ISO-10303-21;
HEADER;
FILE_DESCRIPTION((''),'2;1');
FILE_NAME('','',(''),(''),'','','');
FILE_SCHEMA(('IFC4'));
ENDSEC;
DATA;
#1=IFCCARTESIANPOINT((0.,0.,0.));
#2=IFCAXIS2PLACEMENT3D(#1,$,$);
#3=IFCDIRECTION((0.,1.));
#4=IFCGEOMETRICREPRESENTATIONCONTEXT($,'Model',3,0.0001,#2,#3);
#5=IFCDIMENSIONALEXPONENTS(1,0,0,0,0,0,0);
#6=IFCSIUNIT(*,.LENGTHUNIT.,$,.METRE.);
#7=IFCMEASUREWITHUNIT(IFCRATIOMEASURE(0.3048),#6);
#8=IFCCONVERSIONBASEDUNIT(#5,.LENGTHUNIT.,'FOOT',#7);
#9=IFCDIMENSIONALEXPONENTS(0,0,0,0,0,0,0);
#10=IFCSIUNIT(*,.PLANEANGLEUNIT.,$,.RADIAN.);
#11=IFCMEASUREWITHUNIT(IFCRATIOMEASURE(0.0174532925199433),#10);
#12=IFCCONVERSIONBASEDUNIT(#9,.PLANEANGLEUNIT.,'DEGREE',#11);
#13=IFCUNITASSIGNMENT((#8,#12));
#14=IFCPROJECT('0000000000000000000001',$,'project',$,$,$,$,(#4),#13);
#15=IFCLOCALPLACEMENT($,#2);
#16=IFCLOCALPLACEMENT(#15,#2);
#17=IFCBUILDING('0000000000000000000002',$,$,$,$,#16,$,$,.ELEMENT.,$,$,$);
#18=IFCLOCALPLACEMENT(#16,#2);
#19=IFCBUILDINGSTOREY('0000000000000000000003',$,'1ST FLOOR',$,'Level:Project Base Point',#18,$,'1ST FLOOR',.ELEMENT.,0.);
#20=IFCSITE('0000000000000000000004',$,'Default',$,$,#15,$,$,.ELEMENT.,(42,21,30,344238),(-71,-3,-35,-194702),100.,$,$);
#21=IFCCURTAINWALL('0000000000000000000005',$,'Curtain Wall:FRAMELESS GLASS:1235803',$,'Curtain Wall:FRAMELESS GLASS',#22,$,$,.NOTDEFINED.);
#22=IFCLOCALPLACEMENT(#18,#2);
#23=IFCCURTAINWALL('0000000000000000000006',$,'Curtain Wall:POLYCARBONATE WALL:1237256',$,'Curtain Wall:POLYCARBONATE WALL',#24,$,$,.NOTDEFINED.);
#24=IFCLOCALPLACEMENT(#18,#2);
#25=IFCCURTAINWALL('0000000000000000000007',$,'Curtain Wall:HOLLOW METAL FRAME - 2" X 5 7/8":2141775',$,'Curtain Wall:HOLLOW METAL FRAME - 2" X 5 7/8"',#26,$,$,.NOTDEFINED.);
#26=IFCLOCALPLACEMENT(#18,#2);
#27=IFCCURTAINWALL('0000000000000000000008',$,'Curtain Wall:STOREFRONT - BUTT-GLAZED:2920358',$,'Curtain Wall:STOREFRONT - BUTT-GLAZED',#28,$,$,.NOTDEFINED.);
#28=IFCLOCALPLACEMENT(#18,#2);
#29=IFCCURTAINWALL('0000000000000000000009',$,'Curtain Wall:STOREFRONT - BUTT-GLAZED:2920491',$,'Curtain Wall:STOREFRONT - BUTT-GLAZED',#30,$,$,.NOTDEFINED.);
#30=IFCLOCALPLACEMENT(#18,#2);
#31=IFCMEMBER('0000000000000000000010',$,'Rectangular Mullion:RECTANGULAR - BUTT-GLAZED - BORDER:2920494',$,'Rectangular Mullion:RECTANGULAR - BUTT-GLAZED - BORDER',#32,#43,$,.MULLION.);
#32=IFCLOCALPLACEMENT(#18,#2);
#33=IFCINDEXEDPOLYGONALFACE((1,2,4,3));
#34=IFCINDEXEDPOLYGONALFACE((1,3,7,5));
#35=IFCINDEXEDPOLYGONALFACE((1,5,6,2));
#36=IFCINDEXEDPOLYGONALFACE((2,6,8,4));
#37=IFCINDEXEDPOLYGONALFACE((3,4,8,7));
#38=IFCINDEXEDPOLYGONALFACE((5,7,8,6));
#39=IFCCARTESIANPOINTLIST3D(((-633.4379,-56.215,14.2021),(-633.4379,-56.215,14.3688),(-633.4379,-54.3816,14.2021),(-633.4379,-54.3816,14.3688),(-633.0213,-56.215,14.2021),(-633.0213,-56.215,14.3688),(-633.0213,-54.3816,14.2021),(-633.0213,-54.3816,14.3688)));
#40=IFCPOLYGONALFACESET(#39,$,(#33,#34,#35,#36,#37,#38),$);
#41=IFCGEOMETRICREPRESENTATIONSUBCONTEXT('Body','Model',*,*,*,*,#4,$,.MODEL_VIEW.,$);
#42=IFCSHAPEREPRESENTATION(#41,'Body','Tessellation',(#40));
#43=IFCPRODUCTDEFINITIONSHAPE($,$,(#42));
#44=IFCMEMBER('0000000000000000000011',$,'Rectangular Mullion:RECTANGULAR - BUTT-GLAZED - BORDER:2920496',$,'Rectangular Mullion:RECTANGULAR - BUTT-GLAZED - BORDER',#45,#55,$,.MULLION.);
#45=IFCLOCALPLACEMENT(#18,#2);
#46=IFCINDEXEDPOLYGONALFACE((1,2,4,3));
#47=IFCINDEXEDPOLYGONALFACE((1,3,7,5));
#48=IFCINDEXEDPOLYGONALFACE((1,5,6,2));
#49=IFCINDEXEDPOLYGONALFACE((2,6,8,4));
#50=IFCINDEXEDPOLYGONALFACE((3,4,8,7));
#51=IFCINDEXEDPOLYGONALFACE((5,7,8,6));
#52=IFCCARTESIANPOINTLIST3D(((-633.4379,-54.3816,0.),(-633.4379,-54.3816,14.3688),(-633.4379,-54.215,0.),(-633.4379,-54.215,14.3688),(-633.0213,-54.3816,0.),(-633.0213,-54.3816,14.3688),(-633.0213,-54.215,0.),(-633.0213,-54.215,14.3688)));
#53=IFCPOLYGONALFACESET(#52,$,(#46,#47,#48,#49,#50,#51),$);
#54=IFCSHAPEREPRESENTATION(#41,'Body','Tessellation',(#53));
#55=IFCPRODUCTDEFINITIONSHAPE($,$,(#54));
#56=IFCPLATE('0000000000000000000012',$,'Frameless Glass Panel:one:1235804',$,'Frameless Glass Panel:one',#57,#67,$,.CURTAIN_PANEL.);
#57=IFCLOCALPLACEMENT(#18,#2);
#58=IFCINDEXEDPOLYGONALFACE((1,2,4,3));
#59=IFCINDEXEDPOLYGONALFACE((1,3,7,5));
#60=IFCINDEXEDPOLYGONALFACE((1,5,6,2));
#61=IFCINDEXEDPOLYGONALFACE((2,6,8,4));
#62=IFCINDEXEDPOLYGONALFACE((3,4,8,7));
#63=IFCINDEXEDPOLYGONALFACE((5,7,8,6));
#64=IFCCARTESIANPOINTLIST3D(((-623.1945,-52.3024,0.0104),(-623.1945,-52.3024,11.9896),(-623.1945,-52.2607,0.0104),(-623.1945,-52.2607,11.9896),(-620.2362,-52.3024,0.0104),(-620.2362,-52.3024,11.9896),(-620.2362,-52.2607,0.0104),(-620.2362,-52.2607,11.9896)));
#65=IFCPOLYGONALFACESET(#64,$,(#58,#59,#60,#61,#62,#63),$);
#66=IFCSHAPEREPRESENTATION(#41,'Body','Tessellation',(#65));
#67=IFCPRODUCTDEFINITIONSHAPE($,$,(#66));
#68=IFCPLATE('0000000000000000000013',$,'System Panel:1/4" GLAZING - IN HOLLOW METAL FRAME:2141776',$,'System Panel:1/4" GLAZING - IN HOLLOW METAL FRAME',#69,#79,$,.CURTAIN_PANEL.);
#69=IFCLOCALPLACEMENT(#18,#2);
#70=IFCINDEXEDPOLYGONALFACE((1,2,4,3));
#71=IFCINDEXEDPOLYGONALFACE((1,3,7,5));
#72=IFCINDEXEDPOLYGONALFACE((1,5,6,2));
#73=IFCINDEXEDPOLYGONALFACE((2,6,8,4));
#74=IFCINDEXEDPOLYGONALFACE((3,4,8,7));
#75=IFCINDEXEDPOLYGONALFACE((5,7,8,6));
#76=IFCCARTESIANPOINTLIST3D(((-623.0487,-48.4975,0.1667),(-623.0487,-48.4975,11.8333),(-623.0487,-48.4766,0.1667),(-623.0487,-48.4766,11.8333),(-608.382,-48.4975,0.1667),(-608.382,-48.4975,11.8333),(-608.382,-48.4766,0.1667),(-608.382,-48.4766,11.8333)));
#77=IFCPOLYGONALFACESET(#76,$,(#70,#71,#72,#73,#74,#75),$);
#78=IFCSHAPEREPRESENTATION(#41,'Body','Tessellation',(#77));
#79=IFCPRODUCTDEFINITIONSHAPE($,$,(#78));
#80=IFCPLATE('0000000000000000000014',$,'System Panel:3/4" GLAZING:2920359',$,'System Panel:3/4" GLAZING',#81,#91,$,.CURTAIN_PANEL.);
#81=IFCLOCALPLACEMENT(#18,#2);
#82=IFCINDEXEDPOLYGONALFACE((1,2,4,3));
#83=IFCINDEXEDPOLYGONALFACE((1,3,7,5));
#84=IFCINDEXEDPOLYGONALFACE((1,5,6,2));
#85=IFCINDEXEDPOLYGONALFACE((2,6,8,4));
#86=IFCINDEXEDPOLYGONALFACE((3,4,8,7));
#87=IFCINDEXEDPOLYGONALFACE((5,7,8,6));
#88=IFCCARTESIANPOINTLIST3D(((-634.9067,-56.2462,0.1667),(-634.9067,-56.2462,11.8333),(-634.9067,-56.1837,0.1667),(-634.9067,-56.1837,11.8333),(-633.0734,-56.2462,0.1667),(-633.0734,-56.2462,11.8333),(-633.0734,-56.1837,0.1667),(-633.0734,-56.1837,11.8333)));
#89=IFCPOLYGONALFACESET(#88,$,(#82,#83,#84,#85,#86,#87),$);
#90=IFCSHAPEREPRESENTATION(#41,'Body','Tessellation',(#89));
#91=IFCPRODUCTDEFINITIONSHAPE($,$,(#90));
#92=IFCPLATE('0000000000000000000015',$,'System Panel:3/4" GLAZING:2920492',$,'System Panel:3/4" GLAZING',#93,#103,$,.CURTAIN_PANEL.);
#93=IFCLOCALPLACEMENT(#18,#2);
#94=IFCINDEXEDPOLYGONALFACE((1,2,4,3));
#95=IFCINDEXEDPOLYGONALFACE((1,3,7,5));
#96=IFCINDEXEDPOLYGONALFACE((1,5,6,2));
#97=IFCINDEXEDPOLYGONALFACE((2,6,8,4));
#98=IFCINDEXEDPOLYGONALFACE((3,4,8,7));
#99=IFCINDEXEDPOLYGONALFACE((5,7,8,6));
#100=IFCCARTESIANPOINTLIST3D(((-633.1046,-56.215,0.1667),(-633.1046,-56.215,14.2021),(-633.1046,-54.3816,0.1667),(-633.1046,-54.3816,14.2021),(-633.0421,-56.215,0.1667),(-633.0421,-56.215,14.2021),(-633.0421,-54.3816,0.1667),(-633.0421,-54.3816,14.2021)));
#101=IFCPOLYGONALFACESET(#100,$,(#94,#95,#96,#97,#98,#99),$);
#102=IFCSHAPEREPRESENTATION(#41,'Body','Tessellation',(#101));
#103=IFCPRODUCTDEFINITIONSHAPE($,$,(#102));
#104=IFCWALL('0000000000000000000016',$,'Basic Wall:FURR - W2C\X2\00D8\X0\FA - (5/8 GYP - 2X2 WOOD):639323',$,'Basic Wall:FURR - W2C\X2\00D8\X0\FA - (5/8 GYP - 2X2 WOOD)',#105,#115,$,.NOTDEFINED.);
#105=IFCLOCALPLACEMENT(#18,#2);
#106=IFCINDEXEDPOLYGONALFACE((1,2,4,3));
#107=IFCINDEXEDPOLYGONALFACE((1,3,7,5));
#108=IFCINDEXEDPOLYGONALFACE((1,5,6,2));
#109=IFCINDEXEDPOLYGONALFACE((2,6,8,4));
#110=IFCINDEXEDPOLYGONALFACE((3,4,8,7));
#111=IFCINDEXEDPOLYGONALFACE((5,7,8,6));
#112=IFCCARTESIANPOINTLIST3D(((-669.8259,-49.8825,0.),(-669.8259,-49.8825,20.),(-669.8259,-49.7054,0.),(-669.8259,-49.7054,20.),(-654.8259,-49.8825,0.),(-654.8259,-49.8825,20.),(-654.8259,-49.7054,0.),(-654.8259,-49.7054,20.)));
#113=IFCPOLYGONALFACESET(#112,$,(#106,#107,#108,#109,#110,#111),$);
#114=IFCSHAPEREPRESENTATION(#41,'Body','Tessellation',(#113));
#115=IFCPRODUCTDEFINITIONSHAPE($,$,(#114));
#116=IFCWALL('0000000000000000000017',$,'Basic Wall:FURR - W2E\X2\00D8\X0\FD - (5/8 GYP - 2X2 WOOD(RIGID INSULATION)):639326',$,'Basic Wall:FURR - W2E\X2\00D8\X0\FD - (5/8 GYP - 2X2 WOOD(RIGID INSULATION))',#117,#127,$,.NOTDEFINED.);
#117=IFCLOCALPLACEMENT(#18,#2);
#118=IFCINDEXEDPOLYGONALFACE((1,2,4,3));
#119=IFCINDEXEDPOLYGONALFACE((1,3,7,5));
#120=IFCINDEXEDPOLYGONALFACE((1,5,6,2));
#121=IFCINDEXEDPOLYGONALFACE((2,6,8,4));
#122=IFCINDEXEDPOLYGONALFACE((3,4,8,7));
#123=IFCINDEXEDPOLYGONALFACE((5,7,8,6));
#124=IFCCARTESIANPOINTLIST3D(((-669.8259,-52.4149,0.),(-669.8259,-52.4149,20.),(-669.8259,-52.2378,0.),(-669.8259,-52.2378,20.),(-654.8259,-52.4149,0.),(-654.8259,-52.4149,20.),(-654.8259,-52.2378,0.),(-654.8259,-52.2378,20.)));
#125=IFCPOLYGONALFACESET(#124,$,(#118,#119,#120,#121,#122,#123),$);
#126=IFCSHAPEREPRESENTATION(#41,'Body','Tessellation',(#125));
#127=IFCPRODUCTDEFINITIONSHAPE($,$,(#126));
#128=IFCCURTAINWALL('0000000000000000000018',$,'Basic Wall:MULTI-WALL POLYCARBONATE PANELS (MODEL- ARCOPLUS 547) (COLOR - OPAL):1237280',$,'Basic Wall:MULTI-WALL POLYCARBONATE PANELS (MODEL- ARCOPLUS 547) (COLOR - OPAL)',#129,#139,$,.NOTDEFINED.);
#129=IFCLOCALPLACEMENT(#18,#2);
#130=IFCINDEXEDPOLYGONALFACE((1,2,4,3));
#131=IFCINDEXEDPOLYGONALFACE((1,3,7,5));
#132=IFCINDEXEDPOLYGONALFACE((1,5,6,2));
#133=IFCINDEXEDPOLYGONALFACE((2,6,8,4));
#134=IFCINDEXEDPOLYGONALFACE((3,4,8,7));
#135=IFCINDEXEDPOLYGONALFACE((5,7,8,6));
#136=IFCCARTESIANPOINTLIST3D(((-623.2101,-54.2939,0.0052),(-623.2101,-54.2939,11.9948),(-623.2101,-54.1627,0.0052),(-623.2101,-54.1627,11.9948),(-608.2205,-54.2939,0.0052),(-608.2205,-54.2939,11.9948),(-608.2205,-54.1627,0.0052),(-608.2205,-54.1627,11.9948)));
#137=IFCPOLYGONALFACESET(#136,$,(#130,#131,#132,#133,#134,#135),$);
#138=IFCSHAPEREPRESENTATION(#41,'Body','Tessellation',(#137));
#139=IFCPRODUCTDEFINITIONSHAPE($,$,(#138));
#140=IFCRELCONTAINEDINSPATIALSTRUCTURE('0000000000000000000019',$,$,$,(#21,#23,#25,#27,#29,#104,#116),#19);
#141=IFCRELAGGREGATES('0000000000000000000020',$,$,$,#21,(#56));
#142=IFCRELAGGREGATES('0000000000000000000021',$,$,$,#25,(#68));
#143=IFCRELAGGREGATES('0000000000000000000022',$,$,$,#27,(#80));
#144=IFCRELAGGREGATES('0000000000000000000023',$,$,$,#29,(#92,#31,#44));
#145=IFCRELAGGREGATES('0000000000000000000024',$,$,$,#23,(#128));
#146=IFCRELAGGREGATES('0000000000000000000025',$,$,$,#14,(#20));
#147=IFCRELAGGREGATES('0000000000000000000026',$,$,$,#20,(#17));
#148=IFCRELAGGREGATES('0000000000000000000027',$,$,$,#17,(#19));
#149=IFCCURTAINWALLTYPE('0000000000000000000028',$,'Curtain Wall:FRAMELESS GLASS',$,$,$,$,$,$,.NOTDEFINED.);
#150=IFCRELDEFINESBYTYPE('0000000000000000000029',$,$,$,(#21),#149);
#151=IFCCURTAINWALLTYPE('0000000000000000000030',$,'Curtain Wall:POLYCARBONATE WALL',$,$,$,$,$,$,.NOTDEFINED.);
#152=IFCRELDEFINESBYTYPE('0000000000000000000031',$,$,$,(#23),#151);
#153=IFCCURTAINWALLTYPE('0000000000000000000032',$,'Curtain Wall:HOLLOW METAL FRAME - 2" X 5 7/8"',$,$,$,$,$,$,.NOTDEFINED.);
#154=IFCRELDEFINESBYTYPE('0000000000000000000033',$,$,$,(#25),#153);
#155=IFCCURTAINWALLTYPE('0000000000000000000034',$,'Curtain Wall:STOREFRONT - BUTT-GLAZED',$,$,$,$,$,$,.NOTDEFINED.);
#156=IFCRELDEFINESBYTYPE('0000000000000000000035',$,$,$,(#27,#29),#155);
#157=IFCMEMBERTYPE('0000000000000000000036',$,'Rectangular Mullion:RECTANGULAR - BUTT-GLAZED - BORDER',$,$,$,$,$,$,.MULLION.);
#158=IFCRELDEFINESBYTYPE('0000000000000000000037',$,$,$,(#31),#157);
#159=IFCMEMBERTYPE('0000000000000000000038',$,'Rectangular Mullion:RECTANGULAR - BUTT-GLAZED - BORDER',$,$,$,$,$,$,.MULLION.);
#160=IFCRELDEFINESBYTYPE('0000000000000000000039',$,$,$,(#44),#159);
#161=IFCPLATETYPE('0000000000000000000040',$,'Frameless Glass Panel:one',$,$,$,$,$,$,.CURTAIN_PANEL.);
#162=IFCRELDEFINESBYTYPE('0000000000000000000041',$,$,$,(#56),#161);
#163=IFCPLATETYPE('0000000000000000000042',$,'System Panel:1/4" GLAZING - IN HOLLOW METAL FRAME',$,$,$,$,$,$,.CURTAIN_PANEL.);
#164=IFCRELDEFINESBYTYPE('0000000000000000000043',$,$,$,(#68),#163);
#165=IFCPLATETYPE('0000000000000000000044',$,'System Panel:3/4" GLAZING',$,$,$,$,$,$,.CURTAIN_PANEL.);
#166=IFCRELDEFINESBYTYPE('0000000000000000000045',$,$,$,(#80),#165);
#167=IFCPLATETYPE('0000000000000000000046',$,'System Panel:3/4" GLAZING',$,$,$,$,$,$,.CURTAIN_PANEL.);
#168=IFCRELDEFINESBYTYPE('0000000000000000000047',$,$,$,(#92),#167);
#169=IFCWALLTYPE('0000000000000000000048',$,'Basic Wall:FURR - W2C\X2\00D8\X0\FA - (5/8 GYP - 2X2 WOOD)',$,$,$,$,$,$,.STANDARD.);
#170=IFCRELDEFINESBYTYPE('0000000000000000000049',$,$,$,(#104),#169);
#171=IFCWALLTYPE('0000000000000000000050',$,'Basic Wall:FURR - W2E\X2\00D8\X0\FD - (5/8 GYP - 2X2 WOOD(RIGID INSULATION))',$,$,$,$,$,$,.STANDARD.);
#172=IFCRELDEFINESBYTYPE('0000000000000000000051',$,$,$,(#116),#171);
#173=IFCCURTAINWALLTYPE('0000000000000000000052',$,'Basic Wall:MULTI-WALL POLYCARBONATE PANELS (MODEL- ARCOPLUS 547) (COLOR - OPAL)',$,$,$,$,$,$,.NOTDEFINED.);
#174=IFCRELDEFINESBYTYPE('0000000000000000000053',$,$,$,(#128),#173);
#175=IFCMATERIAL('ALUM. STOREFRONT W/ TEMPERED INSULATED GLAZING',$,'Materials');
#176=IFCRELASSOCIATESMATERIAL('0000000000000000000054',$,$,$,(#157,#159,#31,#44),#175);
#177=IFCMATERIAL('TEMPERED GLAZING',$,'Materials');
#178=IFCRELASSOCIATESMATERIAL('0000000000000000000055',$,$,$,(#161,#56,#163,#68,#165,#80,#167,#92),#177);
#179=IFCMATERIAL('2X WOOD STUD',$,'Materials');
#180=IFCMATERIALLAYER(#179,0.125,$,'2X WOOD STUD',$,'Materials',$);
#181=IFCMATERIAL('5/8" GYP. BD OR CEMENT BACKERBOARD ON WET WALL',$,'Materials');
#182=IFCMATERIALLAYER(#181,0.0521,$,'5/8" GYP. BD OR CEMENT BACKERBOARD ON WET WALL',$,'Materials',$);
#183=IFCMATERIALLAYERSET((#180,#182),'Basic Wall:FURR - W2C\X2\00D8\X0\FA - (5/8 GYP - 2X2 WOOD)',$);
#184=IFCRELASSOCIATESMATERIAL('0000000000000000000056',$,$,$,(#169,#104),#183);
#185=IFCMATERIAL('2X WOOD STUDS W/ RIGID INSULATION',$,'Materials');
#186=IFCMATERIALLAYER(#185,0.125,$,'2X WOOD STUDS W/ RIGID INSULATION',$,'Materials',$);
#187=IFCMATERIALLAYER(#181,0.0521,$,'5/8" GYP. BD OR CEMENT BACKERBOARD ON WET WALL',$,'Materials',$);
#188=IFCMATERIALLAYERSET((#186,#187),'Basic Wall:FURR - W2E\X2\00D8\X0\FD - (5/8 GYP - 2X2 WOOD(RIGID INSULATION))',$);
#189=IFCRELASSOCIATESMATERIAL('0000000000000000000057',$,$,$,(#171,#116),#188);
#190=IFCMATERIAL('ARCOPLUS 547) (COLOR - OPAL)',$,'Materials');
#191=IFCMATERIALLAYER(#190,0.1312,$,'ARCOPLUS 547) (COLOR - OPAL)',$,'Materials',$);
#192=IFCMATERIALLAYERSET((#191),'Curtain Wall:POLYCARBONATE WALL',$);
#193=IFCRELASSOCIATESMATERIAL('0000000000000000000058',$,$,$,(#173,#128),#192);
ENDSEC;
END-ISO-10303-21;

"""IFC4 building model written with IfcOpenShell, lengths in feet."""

from ifc_helpers import new_model, entity, si_unit, converted_unit, direction, frame, frame_2d, origin, origin_2d_with_axis, place, context, subcontext, project, spatial, rectangle, extrude, source, transform, mapped, material, layer, layer_set, layer_usage, material_profile, profile_set, profile_usage, type_object, type_shapes, element, aggregate, save


model = new_model("IFC4")

# Units and contexts
model_context = context("Model", 3, precision=0.0001, world=origin(), true_north=direction((0.0, 1.0)))
body_context = subcontext(model_context, "Body", "Model", "MODEL_VIEW")
ifc_project = project(units=[converted_unit("LENGTHUNIT", "FOOT", entity("IfcRatioMeasure", 0.3048), si_unit("LENGTHUNIT", "METRE"), dimensions=[1, 0, 0, 0, 0, 0, 0]), converted_unit("PLANEANGLEUNIT", "DEGREE", entity("IfcRatioMeasure", 0.0174532925199433), si_unit("PLANEANGLEUNIT", "RADIAN"), dimensions=[0, 0, 0, 0, 0, 0, 0])], contexts=[model_context])

# Site, building, storey
site_placement = place(None, origin())
site = spatial("IfcSite", under=ifc_project, at=site_placement, Name="Default", CompositionType="ELEMENT", RefLatitude=(42, 21, 30, 344238), RefLongitude=(-71, -3, -35, -194702), RefElevation=100.0)
building_placement = place(site_placement, origin())
building = spatial("IfcBuilding", under=site, at=building_placement, CompositionType="ELEMENT")
storey_placement = place(building_placement, origin())
storey = spatial("IfcBuildingStorey", under=building, at=storey_placement, Name="1ST FLOOR", ObjectType="Level:Project Base Point", LongName="1ST FLOOR", CompositionType="ELEMENT", Elevation=0.0)

# Curtain wall
curtain_wall_type_1 = type_object("IfcCurtainWallType", Name="Curtain Wall:FRAMELESS GLASS", PredefinedType="NOTDEFINED")
curtain_wall_1_placement = place(storey_placement, origin())
curtain_wall_1 = element("IfcCurtainWall", 1, at=curtain_wall_1_placement, inside=storey, type_object=curtain_wall_type_1, Name="Curtain Wall:FRAMELESS GLASS:1235803", ObjectType="Curtain Wall:FRAMELESS GLASS", PredefinedType="NOTDEFINED")

# Curtain wall
ifc_material_1 = material(Name="ALUM. STOREFRONT W/ TEMPERED INSULATED GLAZING", Category="Materials")
curtain_wall_type_2 = type_object("IfcCurtainWallType", Name="Curtain Wall:POLYCARBONATE WALL", PredefinedType="NOTDEFINED")
curtain_wall_2_placement = place(storey_placement, origin())
curtain_wall_2 = element("IfcCurtainWall", 2, at=curtain_wall_2_placement, inside=storey, type_object=curtain_wall_type_2, Name="Curtain Wall:POLYCARBONATE WALL:1237256", ObjectType="Curtain Wall:POLYCARBONATE WALL", PredefinedType="NOTDEFINED")

# Curtain wall
curtain_wall_type_3 = type_object("IfcCurtainWallType", Name="Curtain Wall:HOLLOW METAL FRAME - 2\" X 5 7/8\"", PredefinedType="NOTDEFINED")
curtain_wall_3_placement = place(storey_placement, origin())
curtain_wall_3 = element("IfcCurtainWall", 3, at=curtain_wall_3_placement, inside=storey, type_object=curtain_wall_type_3, Name="Curtain Wall:HOLLOW METAL FRAME - 2\" X 5 7/8\":2141775", ObjectType="Curtain Wall:HOLLOW METAL FRAME - 2\" X 5 7/8\"", PredefinedType="NOTDEFINED")

# Curtain walls, members
curtain_wall_type_4 = type_object("IfcCurtainWallType", Name="Curtain Wall:STOREFRONT - BUTT-GLAZED", PredefinedType="NOTDEFINED")
curtain_wall_4_placement = place(storey_placement, origin())
curtain_wall_4 = element("IfcCurtainWall", 4, at=curtain_wall_4_placement, inside=storey, type_object=curtain_wall_type_4, Name="Curtain Wall:STOREFRONT - BUTT-GLAZED:2920358", ObjectType="Curtain Wall:STOREFRONT - BUTT-GLAZED", PredefinedType="NOTDEFINED")
ifc_material_profile_1 = material_profile(ifc_material_1, rectangle(XDim=0.4167, YDim=0.1667, at=frame_2d((0.0, 0.0), x_axis=(1.0, 0.0))), Name="RECTANGULAR - BUTT-GLAZED - BORDER")
ifc_profile_set_1 = profile_set([ifc_material_profile_1], Name="RECTANGULAR - BUTT-GLAZED - BORDER")
curtain_wall_5_placement = place(storey_placement, origin())
curtain_wall_5 = element("IfcCurtainWall", 5, at=curtain_wall_5_placement, inside=storey, type_object=curtain_wall_type_4, Name="Curtain Wall:STOREFRONT - BUTT-GLAZED:2920491", ObjectType="Curtain Wall:STOREFRONT - BUTT-GLAZED", PredefinedType="NOTDEFINED")
ifc_profile_usage_1 = profile_usage(ifc_profile_set_1)
member_type_1 = type_object("IfcMemberType", Name="Rectangular Mullion:RECTANGULAR - BUTT-GLAZED - BORDER", PredefinedType="MULLION", material=ifc_profile_set_1)
shared_shape_1 = source(origin(), body_context, "Body", "SweptSolid", [
    extrude(rectangle(XDim=0.4167, YDim=0.1667, at=frame_2d((0.0, 0.0), x_axis=(1.0, 0.0))), frame((-0.0833, -0.1562, -1.8333), z_axis=(0.0, 0.0, 1.0), x_axis=(0.0, -1.0, 0.0)), (0.0, 0.0, 1.0), 1.8333),
])
type_shapes(member_type_1, [shared_shape_1])
member_1_placement = place(storey_placement, frame((-633.0734, -54.3816, 14.3688), z_axis=(0.0, 1.0, 0.0), x_axis=(0.0, 0.0, 1.0)))
member_1 = element("IfcMember", 6, at=member_1_placement, type_object=member_type_1, material=ifc_profile_usage_1, Name="Rectangular Mullion:RECTANGULAR - BUTT-GLAZED - BORDER:2920494", ObjectType="Rectangular Mullion:RECTANGULAR - BUTT-GLAZED - BORDER", PredefinedType="MULLION", context=body_context, shape_type="MappedRepresentation", body=[
    mapped(shared_shape_1, transform((0.0, 0.0, 0.0), scale=1.0)),
])
ifc_profile_usage_2 = profile_usage(ifc_profile_set_1)
member_type_2 = type_object("IfcMemberType", Name="Rectangular Mullion:RECTANGULAR - BUTT-GLAZED - BORDER", PredefinedType="MULLION", material=ifc_profile_set_1)
shared_shape_2 = source(origin(), body_context, "Body", "SweptSolid", [
    extrude(rectangle(XDim=0.4167, YDim=0.1667, at=frame_2d((0.0, 0.0), x_axis=(1.0, 0.0))), frame((-0.0833, -0.1562, -14.3688), z_axis=(0.0, 0.0, 1.0), x_axis=(0.0, -1.0, 0.0)), (0.0, 0.0, 1.0), 14.3688),
])
type_shapes(member_type_2, [shared_shape_2])
member_2_placement = place(storey_placement, frame((-633.0734, -54.215, 0.0), z_axis=(0.0, 0.0, -1.0), x_axis=(0.0, 1.0, 0.0)))
member_2 = element("IfcMember", 7, at=member_2_placement, type_object=member_type_2, material=ifc_profile_usage_2, Name="Rectangular Mullion:RECTANGULAR - BUTT-GLAZED - BORDER:2920496", ObjectType="Rectangular Mullion:RECTANGULAR - BUTT-GLAZED - BORDER", PredefinedType="MULLION", context=body_context, shape_type="MappedRepresentation", body=[
    mapped(shared_shape_2, transform((0.0, 0.0, 0.0), scale=1.0)),
])

# Plates
ifc_material_2 = material(Name="TEMPERED GLAZING", Category="Materials")
plate_type_1 = type_object("IfcPlateType", Name="Frameless Glass Panel:one", PredefinedType="CURTAIN_PANEL", material=ifc_material_2)
shared_shape_3 = source(origin(), body_context, "Body", "SweptSolid", [
    extrude(rectangle(XDim=0.0417, YDim=2.9583, at=origin_2d_with_axis()), frame((0.0, 0.0, 0.0), z_axis=(0.0, 0.0, 1.0), x_axis=(0.0, 1.0, 0.0)), (0.0, 0.0, 1.0), 11.9792),
])
type_shapes(plate_type_1, [shared_shape_3])
plate_1_placement = place(curtain_wall_1_placement, frame((-621.7153, -52.2815, 0.0104)))
plate_1 = element("IfcPlate", 8, at=plate_1_placement, type_object=plate_type_1, material=ifc_material_2, Name="Frameless Glass Panel:one:1235804", ObjectType="Frameless Glass Panel:one", PredefinedType="CURTAIN_PANEL", context=body_context, shape_type="MappedRepresentation", body=[
    mapped(shared_shape_3, transform((0.0, 0.0, 0.0), scale=1.0)),
])
aggregate(curtain_wall_1, [plate_1])
plate_type_2 = type_object("IfcPlateType", Name="System Panel:1/4\" GLAZING - IN HOLLOW METAL FRAME", PredefinedType="CURTAIN_PANEL", material=ifc_material_2)
shared_shape_4 = source(origin(), body_context, "Body", "SweptSolid", [
    extrude(rectangle(XDim=0.0208, YDim=14.6667, at=frame_2d((0.0, 0.0), x_axis=(1.0, 0.0))), frame((7.3333, 0.0104, 0.0), z_axis=(0.0, 0.0, 1.0), x_axis=(0.0, 1.0, 0.0)), (0.0, 0.0, 1.0), 11.6667),
])
type_shapes(plate_type_2, [shared_shape_4])
plate_2_placement = place(curtain_wall_3_placement, frame((-623.0487, -48.4975, 0.1667)))
plate_2 = element("IfcPlate", 9, at=plate_2_placement, type_object=plate_type_2, material=ifc_material_2, Name="System Panel:1/4\" GLAZING - IN HOLLOW METAL FRAME:2141776", ObjectType="System Panel:1/4\" GLAZING - IN HOLLOW METAL FRAME", PredefinedType="CURTAIN_PANEL", context=body_context, shape_type="MappedRepresentation", body=[
    mapped(shared_shape_4, transform((0.0, 0.0, 0.0), scale=1.0)),
])
aggregate(curtain_wall_3, [plate_2])
plate_type_3 = type_object("IfcPlateType", Name="System Panel:3/4\" GLAZING", PredefinedType="CURTAIN_PANEL", material=ifc_material_2)
shared_shape_5 = source(origin(), body_context, "Body", "SweptSolid", [
    extrude(rectangle(XDim=0.0625, YDim=1.8333, at=origin_2d_with_axis()), frame((0.0, 0.0, 0.0), z_axis=(0.0, 0.0, 1.0), x_axis=(0.0, 1.0, 0.0)), (0.0, 0.0, 1.0), 11.6667),
])
type_shapes(plate_type_3, [shared_shape_5])
plate_3_placement = place(curtain_wall_4_placement, frame((-633.99, -56.215, 0.1667)))
plate_3 = element("IfcPlate", 10, at=plate_3_placement, type_object=plate_type_3, material=ifc_material_2, Name="System Panel:3/4\" GLAZING:2920359", ObjectType="System Panel:3/4\" GLAZING", PredefinedType="CURTAIN_PANEL", context=body_context, shape_type="MappedRepresentation", body=[
    mapped(shared_shape_5, transform((0.0, 0.0, 0.0), scale=1.0)),
])
aggregate(curtain_wall_4, [plate_3])
plate_type_4 = type_object("IfcPlateType", Name="System Panel:3/4\" GLAZING", PredefinedType="CURTAIN_PANEL", material=ifc_material_2)
shared_shape_6 = source(origin(), body_context, "Body", "SweptSolid", [
    extrude(rectangle(XDim=0.0625, YDim=1.8333, at=origin_2d_with_axis()), frame((0.0, 0.0, 0.0), z_axis=(0.0, 0.0, 1.0), x_axis=(0.0, 1.0, 0.0)), (0.0, 0.0, 1.0), 14.0355),
])
type_shapes(plate_type_4, [shared_shape_6])
plate_4_placement = place(curtain_wall_5_placement, frame((-633.0734, -55.2983, 0.1667), z_axis=(0.0, 0.0, 1.0), x_axis=(0.0, 1.0, 0.0)))
plate_4 = element("IfcPlate", 11, at=plate_4_placement, type_object=plate_type_4, material=ifc_material_2, Name="System Panel:3/4\" GLAZING:2920492", ObjectType="System Panel:3/4\" GLAZING", PredefinedType="CURTAIN_PANEL", context=body_context, shape_type="MappedRepresentation", body=[
    mapped(shared_shape_6, transform((0.0, 0.0, 0.0), scale=1.0)),
])
aggregate(curtain_wall_5, [plate_4, member_1, member_2])

# Walls
ifc_material_3 = material(Name="2X WOOD STUD", Category="Materials")
ifc_layer_1 = layer(ifc_material_3, 0.125, Name="2X WOOD STUD", Category="Materials")
ifc_material_4 = material(Name="5/8\" GYP. BD OR CEMENT BACKERBOARD ON WET WALL", Category="Materials")
ifc_layer_2 = layer(ifc_material_4, 0.0521, Name="5/8\" GYP. BD OR CEMENT BACKERBOARD ON WET WALL", Category="Materials")
ifc_layer_set_1 = layer_set([ifc_layer_1, ifc_layer_2], Name="Basic Wall:FURR - W2CØFA - (5/8 GYP - 2X2 WOOD)")
ifc_layer_usage_1 = layer_usage(ifc_layer_set_1, "AXIS2", "NEGATIVE", 0.0885)
wall_type_1 = type_object("IfcWallType", Name="Basic Wall:FURR - W2CØFA - (5/8 GYP - 2X2 WOOD)", PredefinedType="STANDARD", material=ifc_layer_set_1)
wall_1_placement = place(storey_placement, frame((-669.8259, -49.7939, 0.0)))
element("IfcWall", 12, at=wall_1_placement, inside=storey, type_object=wall_type_1, material=ifc_layer_usage_1, Name="Basic Wall:FURR - W2CØFA - (5/8 GYP - 2X2 WOOD):639323", ObjectType="Basic Wall:FURR - W2CØFA - (5/8 GYP - 2X2 WOOD)", PredefinedType="NOTDEFINED", context=body_context, shape_type="SweptSolid", body=[
    extrude(rectangle(XDim=15.0, YDim=0.1771, at=frame_2d((7.5, 0.0), x_axis=(-1.0, 0.0))), origin(), (0.0, 0.0, 1.0), 20.0),
])
ifc_material_5 = material(Name="2X WOOD STUDS W/ RIGID INSULATION", Category="Materials")
ifc_layer_3 = layer(ifc_material_5, 0.125, Name="2X WOOD STUDS W/ RIGID INSULATION", Category="Materials")
ifc_layer_4 = layer(ifc_material_4, 0.0521, Name="5/8\" GYP. BD OR CEMENT BACKERBOARD ON WET WALL", Category="Materials")
ifc_layer_set_2 = layer_set([ifc_layer_3, ifc_layer_4], Name="Basic Wall:FURR - W2EØFD - (5/8 GYP - 2X2 WOOD(RIGID INSULATION))")
ifc_layer_usage_2 = layer_usage(ifc_layer_set_2, "AXIS2", "NEGATIVE", 0.0885)
wall_type_2 = type_object("IfcWallType", Name="Basic Wall:FURR - W2EØFD - (5/8 GYP - 2X2 WOOD(RIGID INSULATION))", PredefinedType="STANDARD", material=ifc_layer_set_2)
wall_2_placement = place(storey_placement, frame((-669.8259, -52.3263, 0.0)))
element("IfcWall", 13, at=wall_2_placement, inside=storey, type_object=wall_type_2, material=ifc_layer_usage_2, Name="Basic Wall:FURR - W2EØFD - (5/8 GYP - 2X2 WOOD(RIGID INSULATION)):639326", ObjectType="Basic Wall:FURR - W2EØFD - (5/8 GYP - 2X2 WOOD(RIGID INSULATION))", PredefinedType="NOTDEFINED", context=body_context, shape_type="SweptSolid", body=[
    extrude(rectangle(XDim=15.0, YDim=0.1771, at=frame_2d((7.5, 0.0), x_axis=(-1.0, 0.0))), origin(), (0.0, 0.0, 1.0), 20.0),
])

# Curtain wall
ifc_material_6 = material(Name="ARCOPLUS 547) (COLOR - OPAL)", Category="Materials")
ifc_layer_5 = layer(ifc_material_6, 0.1312, Name="ARCOPLUS 547) (COLOR - OPAL)", Category="Materials")
ifc_layer_set_3 = layer_set([ifc_layer_5], Name="Curtain Wall:POLYCARBONATE WALL")
ifc_layer_usage_3 = layer_usage(ifc_layer_set_3, "AXIS2", "NEGATIVE", 0.0656)
curtain_wall_type_5 = type_object("IfcCurtainWallType", Name="Basic Wall:MULTI-WALL POLYCARBONATE PANELS (MODEL- ARCOPLUS 547) (COLOR - OPAL)", PredefinedType="NOTDEFINED", material=ifc_layer_set_3)
curtain_wall_6_placement = place(storey_placement, frame((-623.2101, -54.2283, 0.0052)))
curtain_wall_6 = element("IfcCurtainWall", 14, at=curtain_wall_6_placement, type_object=curtain_wall_type_5, material=ifc_layer_usage_3, Name="Basic Wall:MULTI-WALL POLYCARBONATE PANELS (MODEL- ARCOPLUS 547) (COLOR - OPAL):1237280", ObjectType="Basic Wall:MULTI-WALL POLYCARBONATE PANELS (MODEL- ARCOPLUS 547) (COLOR - OPAL)", PredefinedType="NOTDEFINED", context=body_context, shape_type="SweptSolid", body=[
    extrude(rectangle(XDim=14.9896, YDim=0.1312, at=frame_2d((7.4948, 0.0), x_axis=(-1.0, 0.0))), origin(), (0.0, 0.0, 1.0), 11.9896),
])
aggregate(curtain_wall_2, [curtain_wall_6])

save(model, "model.ifc")
